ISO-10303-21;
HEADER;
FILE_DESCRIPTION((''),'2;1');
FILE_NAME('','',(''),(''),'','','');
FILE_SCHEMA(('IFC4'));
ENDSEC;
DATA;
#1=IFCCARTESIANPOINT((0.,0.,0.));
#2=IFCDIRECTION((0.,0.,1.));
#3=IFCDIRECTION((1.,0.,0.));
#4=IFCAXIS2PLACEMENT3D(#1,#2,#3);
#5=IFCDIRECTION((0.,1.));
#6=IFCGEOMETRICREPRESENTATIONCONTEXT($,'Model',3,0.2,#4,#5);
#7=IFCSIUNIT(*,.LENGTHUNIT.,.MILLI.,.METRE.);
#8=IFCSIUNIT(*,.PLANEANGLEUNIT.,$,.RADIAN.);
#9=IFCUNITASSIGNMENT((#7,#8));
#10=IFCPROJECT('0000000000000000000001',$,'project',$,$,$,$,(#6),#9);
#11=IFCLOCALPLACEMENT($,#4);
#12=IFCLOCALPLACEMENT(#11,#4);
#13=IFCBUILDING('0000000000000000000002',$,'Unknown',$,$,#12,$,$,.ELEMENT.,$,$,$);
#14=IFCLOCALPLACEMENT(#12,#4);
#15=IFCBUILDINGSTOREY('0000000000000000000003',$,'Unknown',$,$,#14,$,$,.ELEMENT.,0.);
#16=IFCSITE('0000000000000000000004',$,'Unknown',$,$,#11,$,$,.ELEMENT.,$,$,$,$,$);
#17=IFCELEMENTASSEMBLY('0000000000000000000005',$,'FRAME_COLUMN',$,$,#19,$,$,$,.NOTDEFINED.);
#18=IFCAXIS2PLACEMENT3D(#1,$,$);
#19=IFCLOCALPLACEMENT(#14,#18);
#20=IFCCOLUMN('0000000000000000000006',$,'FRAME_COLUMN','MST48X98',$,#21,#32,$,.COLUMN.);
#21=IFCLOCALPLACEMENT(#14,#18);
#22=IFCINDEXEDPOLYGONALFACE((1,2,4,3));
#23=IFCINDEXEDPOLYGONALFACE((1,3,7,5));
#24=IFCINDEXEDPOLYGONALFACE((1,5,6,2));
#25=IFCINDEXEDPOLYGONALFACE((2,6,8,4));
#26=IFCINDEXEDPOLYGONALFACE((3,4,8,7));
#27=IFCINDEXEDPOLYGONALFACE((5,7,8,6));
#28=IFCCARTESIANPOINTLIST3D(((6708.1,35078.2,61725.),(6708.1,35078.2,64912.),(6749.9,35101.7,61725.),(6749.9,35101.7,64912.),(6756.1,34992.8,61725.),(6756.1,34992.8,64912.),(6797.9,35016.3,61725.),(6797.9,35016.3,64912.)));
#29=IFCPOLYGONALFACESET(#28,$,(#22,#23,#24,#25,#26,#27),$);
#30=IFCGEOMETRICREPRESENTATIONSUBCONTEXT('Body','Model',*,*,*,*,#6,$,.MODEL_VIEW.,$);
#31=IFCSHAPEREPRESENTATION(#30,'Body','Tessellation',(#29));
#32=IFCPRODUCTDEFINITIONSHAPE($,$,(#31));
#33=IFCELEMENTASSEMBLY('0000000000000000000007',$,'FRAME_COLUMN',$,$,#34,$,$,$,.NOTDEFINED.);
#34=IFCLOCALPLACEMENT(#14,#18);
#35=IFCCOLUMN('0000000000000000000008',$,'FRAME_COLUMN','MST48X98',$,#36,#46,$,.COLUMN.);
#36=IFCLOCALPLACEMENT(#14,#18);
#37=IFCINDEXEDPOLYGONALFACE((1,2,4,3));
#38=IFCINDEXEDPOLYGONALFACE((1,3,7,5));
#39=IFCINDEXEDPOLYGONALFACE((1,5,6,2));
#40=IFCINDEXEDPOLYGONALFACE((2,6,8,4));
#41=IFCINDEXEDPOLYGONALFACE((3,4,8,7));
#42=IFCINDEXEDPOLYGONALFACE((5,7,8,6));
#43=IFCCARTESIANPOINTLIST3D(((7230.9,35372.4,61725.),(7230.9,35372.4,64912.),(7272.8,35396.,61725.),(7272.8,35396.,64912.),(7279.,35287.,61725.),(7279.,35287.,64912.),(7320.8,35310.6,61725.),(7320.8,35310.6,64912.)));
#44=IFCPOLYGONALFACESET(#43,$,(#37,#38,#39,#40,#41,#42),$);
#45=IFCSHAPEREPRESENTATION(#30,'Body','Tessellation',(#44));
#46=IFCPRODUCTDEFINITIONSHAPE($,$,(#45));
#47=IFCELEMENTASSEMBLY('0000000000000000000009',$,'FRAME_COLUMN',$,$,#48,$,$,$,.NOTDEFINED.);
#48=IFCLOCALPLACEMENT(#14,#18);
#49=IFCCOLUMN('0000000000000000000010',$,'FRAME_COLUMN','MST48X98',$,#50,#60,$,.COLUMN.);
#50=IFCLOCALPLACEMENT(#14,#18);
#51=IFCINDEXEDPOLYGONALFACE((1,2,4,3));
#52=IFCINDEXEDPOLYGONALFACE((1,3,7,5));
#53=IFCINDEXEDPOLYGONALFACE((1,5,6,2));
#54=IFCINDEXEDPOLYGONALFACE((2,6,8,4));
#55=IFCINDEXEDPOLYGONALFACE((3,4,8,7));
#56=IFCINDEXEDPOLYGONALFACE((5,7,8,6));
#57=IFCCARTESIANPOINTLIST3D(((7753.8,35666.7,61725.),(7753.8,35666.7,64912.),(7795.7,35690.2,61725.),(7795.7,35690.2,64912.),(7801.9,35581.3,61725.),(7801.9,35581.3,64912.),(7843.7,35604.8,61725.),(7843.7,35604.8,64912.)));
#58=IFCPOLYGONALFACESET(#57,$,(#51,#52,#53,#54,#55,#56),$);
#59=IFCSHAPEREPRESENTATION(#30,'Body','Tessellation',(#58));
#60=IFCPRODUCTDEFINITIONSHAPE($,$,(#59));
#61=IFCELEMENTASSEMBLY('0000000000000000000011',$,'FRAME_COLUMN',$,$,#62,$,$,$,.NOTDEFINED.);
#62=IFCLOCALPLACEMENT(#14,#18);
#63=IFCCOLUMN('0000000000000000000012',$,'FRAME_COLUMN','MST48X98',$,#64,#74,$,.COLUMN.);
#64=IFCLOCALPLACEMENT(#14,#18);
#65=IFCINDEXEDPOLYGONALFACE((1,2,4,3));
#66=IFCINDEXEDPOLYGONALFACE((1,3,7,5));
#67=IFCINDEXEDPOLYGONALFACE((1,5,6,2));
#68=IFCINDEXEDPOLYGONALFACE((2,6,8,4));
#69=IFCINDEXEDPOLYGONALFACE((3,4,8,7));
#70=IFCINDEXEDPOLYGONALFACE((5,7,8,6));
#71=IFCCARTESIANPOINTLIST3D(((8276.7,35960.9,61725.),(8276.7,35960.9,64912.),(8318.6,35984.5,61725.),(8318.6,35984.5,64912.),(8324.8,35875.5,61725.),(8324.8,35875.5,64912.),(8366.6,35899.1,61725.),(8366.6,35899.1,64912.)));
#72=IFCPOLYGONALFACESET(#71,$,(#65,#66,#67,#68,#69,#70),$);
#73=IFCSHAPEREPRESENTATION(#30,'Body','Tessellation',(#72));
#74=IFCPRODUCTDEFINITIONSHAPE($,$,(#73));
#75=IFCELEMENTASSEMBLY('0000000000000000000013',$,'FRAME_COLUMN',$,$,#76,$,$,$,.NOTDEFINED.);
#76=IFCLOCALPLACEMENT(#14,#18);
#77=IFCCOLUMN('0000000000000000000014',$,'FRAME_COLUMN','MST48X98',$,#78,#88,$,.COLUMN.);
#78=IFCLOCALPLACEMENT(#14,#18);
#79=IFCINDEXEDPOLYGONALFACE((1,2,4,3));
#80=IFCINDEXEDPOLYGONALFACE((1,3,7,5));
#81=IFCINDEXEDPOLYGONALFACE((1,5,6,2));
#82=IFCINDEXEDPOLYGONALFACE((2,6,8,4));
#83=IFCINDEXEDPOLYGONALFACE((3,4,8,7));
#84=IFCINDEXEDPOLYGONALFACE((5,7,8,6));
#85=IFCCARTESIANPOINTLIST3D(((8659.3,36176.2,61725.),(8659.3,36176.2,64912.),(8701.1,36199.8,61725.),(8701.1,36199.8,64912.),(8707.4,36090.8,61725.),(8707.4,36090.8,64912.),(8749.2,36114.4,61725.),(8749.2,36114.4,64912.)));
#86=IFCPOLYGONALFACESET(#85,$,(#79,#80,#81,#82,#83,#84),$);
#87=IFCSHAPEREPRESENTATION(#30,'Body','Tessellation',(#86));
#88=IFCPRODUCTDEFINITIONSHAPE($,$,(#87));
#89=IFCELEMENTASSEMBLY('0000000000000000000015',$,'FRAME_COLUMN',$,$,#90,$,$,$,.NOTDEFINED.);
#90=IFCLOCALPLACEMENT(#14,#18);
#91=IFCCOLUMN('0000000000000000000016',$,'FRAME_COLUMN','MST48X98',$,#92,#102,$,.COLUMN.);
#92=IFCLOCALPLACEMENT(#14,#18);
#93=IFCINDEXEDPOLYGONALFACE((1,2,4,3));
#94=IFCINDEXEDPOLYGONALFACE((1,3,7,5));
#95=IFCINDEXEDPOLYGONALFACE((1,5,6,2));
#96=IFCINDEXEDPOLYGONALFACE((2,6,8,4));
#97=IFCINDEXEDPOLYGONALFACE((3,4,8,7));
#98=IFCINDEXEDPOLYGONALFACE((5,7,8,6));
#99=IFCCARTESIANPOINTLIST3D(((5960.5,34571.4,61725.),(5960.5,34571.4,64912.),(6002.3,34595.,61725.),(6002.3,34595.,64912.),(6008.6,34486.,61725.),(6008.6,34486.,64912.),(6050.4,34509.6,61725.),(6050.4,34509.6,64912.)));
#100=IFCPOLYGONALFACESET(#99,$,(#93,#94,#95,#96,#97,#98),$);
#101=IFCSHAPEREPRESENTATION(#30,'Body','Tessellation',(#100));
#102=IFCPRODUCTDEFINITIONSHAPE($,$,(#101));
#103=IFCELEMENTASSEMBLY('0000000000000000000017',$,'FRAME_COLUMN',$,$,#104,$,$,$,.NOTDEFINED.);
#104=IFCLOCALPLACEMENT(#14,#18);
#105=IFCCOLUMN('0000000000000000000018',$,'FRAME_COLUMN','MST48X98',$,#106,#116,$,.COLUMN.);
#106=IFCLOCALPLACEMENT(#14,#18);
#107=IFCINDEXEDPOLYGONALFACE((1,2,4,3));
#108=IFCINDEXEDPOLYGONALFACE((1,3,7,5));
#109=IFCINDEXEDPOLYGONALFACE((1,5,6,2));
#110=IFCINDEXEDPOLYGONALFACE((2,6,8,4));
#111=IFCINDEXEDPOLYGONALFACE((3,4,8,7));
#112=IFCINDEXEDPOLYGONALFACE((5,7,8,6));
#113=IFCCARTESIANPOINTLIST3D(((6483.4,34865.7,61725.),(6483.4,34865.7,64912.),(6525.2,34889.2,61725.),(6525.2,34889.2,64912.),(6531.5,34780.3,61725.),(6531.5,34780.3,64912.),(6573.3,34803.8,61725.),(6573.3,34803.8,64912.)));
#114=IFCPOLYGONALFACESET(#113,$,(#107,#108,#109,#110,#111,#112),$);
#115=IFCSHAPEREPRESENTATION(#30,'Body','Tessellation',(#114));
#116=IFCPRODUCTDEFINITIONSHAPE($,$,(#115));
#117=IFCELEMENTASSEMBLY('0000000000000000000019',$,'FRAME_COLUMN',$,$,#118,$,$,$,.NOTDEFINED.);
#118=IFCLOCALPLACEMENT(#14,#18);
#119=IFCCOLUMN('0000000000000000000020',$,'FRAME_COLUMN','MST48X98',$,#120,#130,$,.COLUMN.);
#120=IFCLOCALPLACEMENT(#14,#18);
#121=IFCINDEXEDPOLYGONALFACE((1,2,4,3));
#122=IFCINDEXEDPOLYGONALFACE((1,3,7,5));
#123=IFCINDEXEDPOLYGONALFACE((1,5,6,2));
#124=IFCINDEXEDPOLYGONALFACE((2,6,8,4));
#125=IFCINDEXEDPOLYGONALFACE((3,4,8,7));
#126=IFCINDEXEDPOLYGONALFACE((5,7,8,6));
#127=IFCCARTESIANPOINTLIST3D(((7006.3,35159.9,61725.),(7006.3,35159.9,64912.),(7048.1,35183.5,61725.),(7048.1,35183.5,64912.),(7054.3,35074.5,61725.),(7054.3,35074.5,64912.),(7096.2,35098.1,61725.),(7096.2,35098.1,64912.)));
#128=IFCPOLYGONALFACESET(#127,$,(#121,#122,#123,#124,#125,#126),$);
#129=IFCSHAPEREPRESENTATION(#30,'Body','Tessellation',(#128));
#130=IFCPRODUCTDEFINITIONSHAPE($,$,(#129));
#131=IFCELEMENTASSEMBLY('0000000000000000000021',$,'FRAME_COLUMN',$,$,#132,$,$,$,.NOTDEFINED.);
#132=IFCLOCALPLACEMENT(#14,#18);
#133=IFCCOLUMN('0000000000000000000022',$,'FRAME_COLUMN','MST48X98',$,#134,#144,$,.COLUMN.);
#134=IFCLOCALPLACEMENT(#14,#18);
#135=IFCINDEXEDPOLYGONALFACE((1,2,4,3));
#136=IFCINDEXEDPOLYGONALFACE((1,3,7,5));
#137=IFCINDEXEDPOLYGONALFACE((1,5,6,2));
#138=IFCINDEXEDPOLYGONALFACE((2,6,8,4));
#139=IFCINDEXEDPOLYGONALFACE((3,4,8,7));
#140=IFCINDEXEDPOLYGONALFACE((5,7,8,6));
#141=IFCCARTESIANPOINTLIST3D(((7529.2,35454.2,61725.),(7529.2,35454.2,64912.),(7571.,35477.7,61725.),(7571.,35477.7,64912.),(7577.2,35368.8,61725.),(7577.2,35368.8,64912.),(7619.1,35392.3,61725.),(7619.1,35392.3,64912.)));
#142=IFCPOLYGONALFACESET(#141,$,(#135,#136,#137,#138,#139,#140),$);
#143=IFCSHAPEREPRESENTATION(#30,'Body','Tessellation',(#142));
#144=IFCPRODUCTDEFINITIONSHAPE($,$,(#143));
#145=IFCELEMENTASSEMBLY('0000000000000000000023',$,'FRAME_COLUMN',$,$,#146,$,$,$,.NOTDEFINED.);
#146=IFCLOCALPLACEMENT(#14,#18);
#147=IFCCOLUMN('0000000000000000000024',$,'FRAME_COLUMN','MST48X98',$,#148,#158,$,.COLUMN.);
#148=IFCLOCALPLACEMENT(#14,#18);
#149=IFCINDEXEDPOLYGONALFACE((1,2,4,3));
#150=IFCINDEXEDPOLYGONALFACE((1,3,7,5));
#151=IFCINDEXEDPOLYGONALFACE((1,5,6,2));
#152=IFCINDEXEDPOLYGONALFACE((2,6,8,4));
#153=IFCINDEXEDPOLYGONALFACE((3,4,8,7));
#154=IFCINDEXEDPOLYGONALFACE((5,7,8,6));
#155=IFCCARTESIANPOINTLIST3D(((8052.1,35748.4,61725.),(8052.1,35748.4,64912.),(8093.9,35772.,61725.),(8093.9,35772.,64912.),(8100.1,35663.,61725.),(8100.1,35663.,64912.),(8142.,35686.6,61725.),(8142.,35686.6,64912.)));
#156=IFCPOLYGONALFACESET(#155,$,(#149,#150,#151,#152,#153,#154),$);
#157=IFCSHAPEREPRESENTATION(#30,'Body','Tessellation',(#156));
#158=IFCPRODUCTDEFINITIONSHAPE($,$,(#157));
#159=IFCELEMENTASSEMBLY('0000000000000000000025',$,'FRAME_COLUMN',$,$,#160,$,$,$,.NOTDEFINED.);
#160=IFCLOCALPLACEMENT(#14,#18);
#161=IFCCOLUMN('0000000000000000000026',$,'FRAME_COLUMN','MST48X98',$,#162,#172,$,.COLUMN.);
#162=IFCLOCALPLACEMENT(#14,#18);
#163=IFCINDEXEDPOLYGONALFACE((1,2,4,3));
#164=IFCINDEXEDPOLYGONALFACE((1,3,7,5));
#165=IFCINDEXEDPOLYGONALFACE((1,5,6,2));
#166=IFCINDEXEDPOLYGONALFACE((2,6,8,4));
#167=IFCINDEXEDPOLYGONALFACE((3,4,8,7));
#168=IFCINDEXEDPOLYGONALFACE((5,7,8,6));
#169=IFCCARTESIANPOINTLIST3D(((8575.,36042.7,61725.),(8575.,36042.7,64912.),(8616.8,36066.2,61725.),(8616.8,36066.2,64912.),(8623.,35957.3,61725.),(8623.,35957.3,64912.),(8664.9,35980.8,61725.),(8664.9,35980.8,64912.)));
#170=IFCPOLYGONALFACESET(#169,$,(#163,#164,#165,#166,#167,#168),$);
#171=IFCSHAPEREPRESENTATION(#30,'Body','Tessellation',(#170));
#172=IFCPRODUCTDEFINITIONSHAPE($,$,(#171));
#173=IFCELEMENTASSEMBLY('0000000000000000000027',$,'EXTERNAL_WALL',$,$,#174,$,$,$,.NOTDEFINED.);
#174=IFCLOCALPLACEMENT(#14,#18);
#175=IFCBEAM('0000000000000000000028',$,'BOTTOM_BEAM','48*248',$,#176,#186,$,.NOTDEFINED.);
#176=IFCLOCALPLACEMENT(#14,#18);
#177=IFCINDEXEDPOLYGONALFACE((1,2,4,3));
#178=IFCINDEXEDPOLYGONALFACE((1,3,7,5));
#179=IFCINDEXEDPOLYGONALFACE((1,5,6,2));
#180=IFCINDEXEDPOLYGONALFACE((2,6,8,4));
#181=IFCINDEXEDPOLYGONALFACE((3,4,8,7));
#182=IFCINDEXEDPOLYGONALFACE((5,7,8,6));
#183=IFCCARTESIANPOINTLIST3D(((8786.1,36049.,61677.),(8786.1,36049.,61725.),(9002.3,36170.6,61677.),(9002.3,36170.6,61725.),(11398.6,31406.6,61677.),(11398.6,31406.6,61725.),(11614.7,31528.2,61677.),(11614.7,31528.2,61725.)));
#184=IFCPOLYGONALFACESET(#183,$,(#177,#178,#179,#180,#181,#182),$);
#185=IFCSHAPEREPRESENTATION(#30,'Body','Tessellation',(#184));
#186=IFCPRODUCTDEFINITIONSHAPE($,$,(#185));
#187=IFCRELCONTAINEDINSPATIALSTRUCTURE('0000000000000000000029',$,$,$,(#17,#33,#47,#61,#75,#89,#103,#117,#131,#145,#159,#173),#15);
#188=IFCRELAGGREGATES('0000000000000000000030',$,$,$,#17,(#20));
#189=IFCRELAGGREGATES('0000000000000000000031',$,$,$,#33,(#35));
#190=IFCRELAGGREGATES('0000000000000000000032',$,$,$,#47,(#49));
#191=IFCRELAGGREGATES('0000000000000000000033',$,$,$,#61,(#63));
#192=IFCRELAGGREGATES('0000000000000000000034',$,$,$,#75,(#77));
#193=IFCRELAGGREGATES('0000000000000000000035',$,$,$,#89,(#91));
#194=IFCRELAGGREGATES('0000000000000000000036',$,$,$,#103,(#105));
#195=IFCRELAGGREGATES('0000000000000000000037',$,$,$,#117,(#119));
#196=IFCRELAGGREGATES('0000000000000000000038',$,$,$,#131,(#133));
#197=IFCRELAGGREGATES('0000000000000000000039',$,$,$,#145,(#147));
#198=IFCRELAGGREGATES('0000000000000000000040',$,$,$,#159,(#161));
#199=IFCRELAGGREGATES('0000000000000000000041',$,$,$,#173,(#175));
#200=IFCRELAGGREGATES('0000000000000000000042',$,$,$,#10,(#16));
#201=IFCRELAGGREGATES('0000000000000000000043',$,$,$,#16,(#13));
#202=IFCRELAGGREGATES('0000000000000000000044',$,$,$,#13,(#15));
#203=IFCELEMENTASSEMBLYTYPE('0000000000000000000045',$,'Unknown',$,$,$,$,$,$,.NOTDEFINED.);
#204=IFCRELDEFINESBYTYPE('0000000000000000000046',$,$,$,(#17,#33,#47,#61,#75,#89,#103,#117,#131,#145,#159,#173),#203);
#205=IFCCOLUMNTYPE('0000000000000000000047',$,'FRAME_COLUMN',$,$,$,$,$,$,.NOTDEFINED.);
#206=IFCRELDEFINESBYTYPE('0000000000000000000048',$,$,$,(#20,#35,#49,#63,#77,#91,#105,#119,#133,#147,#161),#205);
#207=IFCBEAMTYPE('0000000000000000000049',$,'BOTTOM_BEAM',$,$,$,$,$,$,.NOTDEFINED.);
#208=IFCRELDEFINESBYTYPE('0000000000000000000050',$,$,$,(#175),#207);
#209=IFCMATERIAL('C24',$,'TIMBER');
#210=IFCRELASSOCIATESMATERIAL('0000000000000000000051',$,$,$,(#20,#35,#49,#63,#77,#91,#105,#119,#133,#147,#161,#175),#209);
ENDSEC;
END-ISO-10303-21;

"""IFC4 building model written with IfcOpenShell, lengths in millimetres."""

from ifc_helpers import new_model, si_unit, direction, frame, origin_with_axes, origin_2d_with_axis, place, context, subcontext, project, spatial, polyline, rectangle, outline, extrude, material, material_profile, profile_set, profile_usage, type_object, element, aggregate, save


model = new_model("IFC4")

# Units and contexts
model_context = context("Model", 3, precision=0.2, world=origin_with_axes(), true_north=direction((0.0, 1.0)))
body_context = subcontext(model_context, "Body", "Model", "MODEL_VIEW")
ifc_project = project(units=[si_unit("LENGTHUNIT", "METRE", prefix="MILLI"), si_unit("PLANEANGLEUNIT", "RADIAN")], contexts=[model_context])

# Site, building, storey
site_placement = place(None, origin_with_axes())
site = spatial("IfcSite", under=ifc_project, at=site_placement, Name="Unknown", CompositionType="ELEMENT")
building_placement = place(site_placement, origin_with_axes())
building = spatial("IfcBuilding", under=site, at=building_placement, Name="Unknown", CompositionType="ELEMENT")
storey_placement = place(building_placement, origin_with_axes())
storey = spatial("IfcBuildingStorey", under=building, at=storey_placement, Name="Unknown", CompositionType="ELEMENT", Elevation=0.0)

# Element assemblies, columns
element_assembly_type = type_object("IfcElementAssemblyType", Name="Unknown", PredefinedType="NOTDEFINED")
ifc_material = material(Name="C24", Category="TIMBER")
ifc_material_profile_1 = material_profile(ifc_material, outline(polyline([(-24.0, 49.0), (-24.0, -49.0), (24.0, -49.0), (24.0, 49.0), (-24.0, 49.0)])), Name="MST48X98")
ifc_profile_set_1 = profile_set([ifc_material_profile_1])
ifc_profile_usage_1 = profile_usage(ifc_profile_set_1, cardinal=7)
column_type = type_object("IfcColumnType", Name="FRAME_COLUMN")
ifc_profile_usage_2 = profile_usage(ifc_profile_set_1, cardinal=9)
assembly_1_placement = place(storey_placement, frame((6753.0, 35047.2, 61725.0), z_axis=(-0.871487, -0.490418, 0.0), x_axis=(0.0, 0.0, 1.0)))
assembly_1 = element("IfcElementAssembly", 1, at=assembly_1_placement, inside=storey, type_object=element_assembly_type, Name="FRAME_COLUMN", PredefinedType="NOTDEFINED")
column_1_placement = place(assembly_1_placement, origin_with_axes())
column_1 = element("IfcColumn", 2, at=column_1_placement, type_object=column_type, material=ifc_profile_usage_1, Name="FRAME_COLUMN", Description="MST48X98", PredefinedType="COLUMN", context=body_context, shape_type="SolidModel", body=[
    extrude(outline(polyline([(-24.0, 49.0), (-24.0, -49.0), (24.0, -49.0), (24.0, 49.0), (-24.0, 49.0)])), frame((0.0, 0.0, 0.0), z_axis=(-1.0, 0.0, 0.0), x_axis=(0.0, 0.0, 1.0)), (0.0, 0.0, -1.0), 3187.0),
])
aggregate(assembly_1, [column_1])
assembly_2_placement = place(storey_placement, frame((7275.9, 35341.5, 61725.0), z_axis=(-0.871487, -0.490418, 0.0), x_axis=(0.0, 0.0, 1.0)))
assembly_2 = element("IfcElementAssembly", 3, at=assembly_2_placement, inside=storey, type_object=element_assembly_type, Name="FRAME_COLUMN", PredefinedType="NOTDEFINED")
column_2_placement = place(assembly_2_placement, origin_with_axes())
column_2 = element("IfcColumn", 4, at=column_2_placement, type_object=column_type, material=ifc_profile_usage_1, Name="FRAME_COLUMN", Description="MST48X98", PredefinedType="COLUMN", context=body_context, shape_type="SolidModel", body=[
    extrude(outline(polyline([(-24.0, 49.0), (-24.0, -49.0), (24.0, -49.0), (24.0, 49.0), (-24.0, 49.0)])), frame((0.0, 0.0, 0.0), z_axis=(-1.0, 0.0, 0.0), x_axis=(0.0, 0.0, 1.0)), (0.0, 0.0, -1.0), 3187.0),
])
aggregate(assembly_2, [column_2])
assembly_3_placement = place(storey_placement, frame((7798.8, 35635.7, 61725.0), z_axis=(-0.871487, -0.490418, 0.0), x_axis=(0.0, 0.0, 1.0)))
assembly_3 = element("IfcElementAssembly", 5, at=assembly_3_placement, inside=storey, type_object=element_assembly_type, Name="FRAME_COLUMN", PredefinedType="NOTDEFINED")
column_3_placement = place(assembly_3_placement, origin_with_axes())
column_3 = element("IfcColumn", 6, at=column_3_placement, type_object=column_type, material=ifc_profile_usage_1, Name="FRAME_COLUMN", Description="MST48X98", PredefinedType="COLUMN", context=body_context, shape_type="SolidModel", body=[
    extrude(outline(polyline([(-24.0, 49.0), (-24.0, -49.0), (24.0, -49.0), (24.0, 49.0), (-24.0, 49.0)])), frame((0.0, 0.0, 0.0), z_axis=(-1.0, 0.0, 0.0), x_axis=(0.0, 0.0, 1.0)), (0.0, 0.0, -1.0), 3187.0),
])
aggregate(assembly_3, [column_3])
assembly_4_placement = place(storey_placement, frame((8321.7, 35930.0, 61725.0), z_axis=(-0.871487, -0.490418, 0.0), x_axis=(0.0, 0.0, 1.0)))
assembly_4 = element("IfcElementAssembly", 7, at=assembly_4_placement, inside=storey, type_object=element_assembly_type, Name="FRAME_COLUMN", PredefinedType="NOTDEFINED")
column_4_placement = place(assembly_4_placement, origin_with_axes())
column_4 = element("IfcColumn", 8, at=column_4_placement, type_object=column_type, material=ifc_profile_usage_1, Name="FRAME_COLUMN", Description="MST48X98", PredefinedType="COLUMN", context=body_context, shape_type="SolidModel", body=[
    extrude(outline(polyline([(-24.0, 49.0), (-24.0, -49.0), (24.0, -49.0), (24.0, 49.0), (-24.0, 49.0)])), frame((0.0, 0.0, 0.0), z_axis=(-1.0, 0.0, 0.0), x_axis=(0.0, 0.0, 1.0)), (0.0, 0.0, -1.0), 3187.0),
])
aggregate(assembly_4, [column_4])
assembly_5_placement = place(storey_placement, frame((8704.3, 36145.3, 61725.0), z_axis=(-0.871487, -0.490418, 0.0), x_axis=(0.0, 0.0, 1.0)))
assembly_5 = element("IfcElementAssembly", 9, at=assembly_5_placement, inside=storey, type_object=element_assembly_type, Name="FRAME_COLUMN", PredefinedType="NOTDEFINED")
column_5_placement = place(assembly_5_placement, origin_with_axes())
column_5 = element("IfcColumn", 10, at=column_5_placement, type_object=column_type, material=ifc_profile_usage_1, Name="FRAME_COLUMN", Description="MST48X98", PredefinedType="COLUMN", context=body_context, shape_type="SolidModel", body=[
    extrude(outline(polyline([(-24.0, 49.0), (-24.0, -49.0), (24.0, -49.0), (24.0, 49.0), (-24.0, 49.0)])), frame((0.0, 0.0, 0.0), z_axis=(-1.0, 0.0, 0.0), x_axis=(0.0, 0.0, 1.0)), (0.0, 0.0, -1.0), 3187.0),
])
aggregate(assembly_5, [column_5])
assembly_6_placement = place(storey_placement, frame((6005.4, 34540.5, 61725.0), z_axis=(-0.871487, -0.490418, 0.0), x_axis=(0.0, 0.0, 1.0)))
assembly_6 = element("IfcElementAssembly", 11, at=assembly_6_placement, inside=storey, type_object=element_assembly_type, Name="FRAME_COLUMN", PredefinedType="NOTDEFINED")
column_6_placement = place(assembly_6_placement, origin_with_axes())
column_6 = element("IfcColumn", 12, at=column_6_placement, type_object=column_type, material=ifc_profile_usage_2, Name="FRAME_COLUMN", Description="MST48X98", PredefinedType="COLUMN", context=body_context, shape_type="SolidModel", body=[
    extrude(outline(polyline([(-24.0, 49.0), (-24.0, -49.0), (24.0, -49.0), (24.0, 49.0), (-24.0, 49.0)])), frame((0.0, 0.0, 0.0), z_axis=(-1.0, 0.0, 0.0), x_axis=(0.0, 0.0, 1.0)), (0.0, 0.0, -1.0), 3187.0),
])
aggregate(assembly_6, [column_6])
assembly_7_placement = place(storey_placement, frame((6528.3, 34834.8, 61725.0), z_axis=(-0.871487, -0.490418, 0.0), x_axis=(0.0, 0.0, 1.0)))
assembly_7 = element("IfcElementAssembly", 13, at=assembly_7_placement, inside=storey, type_object=element_assembly_type, Name="FRAME_COLUMN", PredefinedType="NOTDEFINED")
column_7_placement = place(assembly_7_placement, origin_with_axes())
column_7 = element("IfcColumn", 14, at=column_7_placement, type_object=column_type, material=ifc_profile_usage_2, Name="FRAME_COLUMN", Description="MST48X98", PredefinedType="COLUMN", context=body_context, shape_type="SolidModel", body=[
    extrude(outline(polyline([(-24.0, 49.0), (-24.0, -49.0), (24.0, -49.0), (24.0, 49.0), (-24.0, 49.0)])), frame((0.0, 0.0, 0.0), z_axis=(-1.0, 0.0, 0.0), x_axis=(0.0, 0.0, 1.0)), (0.0, 0.0, -1.0), 3187.0),
])
aggregate(assembly_7, [column_7])
assembly_8_placement = place(storey_placement, frame((7051.2, 35129.0, 61725.0), z_axis=(-0.871487, -0.490418, 0.0), x_axis=(0.0, 0.0, 1.0)))
assembly_8 = element("IfcElementAssembly", 15, at=assembly_8_placement, inside=storey, type_object=element_assembly_type, Name="FRAME_COLUMN", PredefinedType="NOTDEFINED")
column_8_placement = place(assembly_8_placement, origin_with_axes())
column_8 = element("IfcColumn", 16, at=column_8_placement, type_object=column_type, material=ifc_profile_usage_2, Name="FRAME_COLUMN", Description="MST48X98", PredefinedType="COLUMN", context=body_context, shape_type="SolidModel", body=[
    extrude(outline(polyline([(-24.0, 49.0), (-24.0, -49.0), (24.0, -49.0), (24.0, 49.0), (-24.0, 49.0)])), frame((0.0, 0.0, 0.0), z_axis=(-1.0, 0.0, 0.0), x_axis=(0.0, 0.0, 1.0)), (0.0, 0.0, -1.0), 3187.0),
])
aggregate(assembly_8, [column_8])
assembly_9_placement = place(storey_placement, frame((7574.1, 35423.3, 61725.0), z_axis=(-0.871487, -0.490418, 0.0), x_axis=(0.0, 0.0, 1.0)))
assembly_9 = element("IfcElementAssembly", 17, at=assembly_9_placement, inside=storey, type_object=element_assembly_type, Name="FRAME_COLUMN", PredefinedType="NOTDEFINED")
column_9_placement = place(assembly_9_placement, origin_with_axes())
column_9 = element("IfcColumn", 18, at=column_9_placement, type_object=column_type, material=ifc_profile_usage_2, Name="FRAME_COLUMN", Description="MST48X98", PredefinedType="COLUMN", context=body_context, shape_type="SolidModel", body=[
    extrude(outline(polyline([(-24.0, 49.0), (-24.0, -49.0), (24.0, -49.0), (24.0, 49.0), (-24.0, 49.0)])), frame((0.0, 0.0, 0.0), z_axis=(-1.0, 0.0, 0.0), x_axis=(0.0, 0.0, 1.0)), (0.0, 0.0, -1.0), 3187.0),
])
aggregate(assembly_9, [column_9])
assembly_10_placement = place(storey_placement, frame((8097.0, 35717.5, 61725.0), z_axis=(-0.871487, -0.490418, 0.0), x_axis=(0.0, 0.0, 1.0)))
assembly_10 = element("IfcElementAssembly", 19, at=assembly_10_placement, inside=storey, type_object=element_assembly_type, Name="FRAME_COLUMN", PredefinedType="NOTDEFINED")
column_10_placement = place(assembly_10_placement, origin_with_axes())
column_10 = element("IfcColumn", 20, at=column_10_placement, type_object=column_type, material=ifc_profile_usage_2, Name="FRAME_COLUMN", Description="MST48X98", PredefinedType="COLUMN", context=body_context, shape_type="SolidModel", body=[
    extrude(outline(polyline([(-24.0, 49.0), (-24.0, -49.0), (24.0, -49.0), (24.0, 49.0), (-24.0, 49.0)])), frame((0.0, 0.0, 0.0), z_axis=(-1.0, 0.0, 0.0), x_axis=(0.0, 0.0, 1.0)), (0.0, 0.0, -1.0), 3187.0),
])
aggregate(assembly_10, [column_10])
assembly_11_placement = place(storey_placement, frame((8619.9, 36011.8, 61725.0), z_axis=(-0.871487, -0.490418, 0.0), x_axis=(0.0, 0.0, 1.0)))
assembly_11 = element("IfcElementAssembly", 21, at=assembly_11_placement, inside=storey, type_object=element_assembly_type, Name="FRAME_COLUMN", PredefinedType="NOTDEFINED")
column_11_placement = place(assembly_11_placement, origin_with_axes())
column_11 = element("IfcColumn", 22, at=column_11_placement, type_object=column_type, material=ifc_profile_usage_2, Name="FRAME_COLUMN", Description="MST48X98", PredefinedType="COLUMN", context=body_context, shape_type="SolidModel", body=[
    extrude(outline(polyline([(-24.0, 49.0), (-24.0, -49.0), (24.0, -49.0), (24.0, 49.0), (-24.0, 49.0)])), frame((0.0, 0.0, 0.0), z_axis=(-1.0, 0.0, 0.0), x_axis=(0.0, 0.0, 1.0)), (0.0, 0.0, -1.0), 3187.0),
])
aggregate(assembly_11, [column_11])

# Element assembly, beam
assembly_12_placement = place(storey_placement, frame((8894.2, 36109.8, 64936.0), z_axis=(-0.871487, -0.490418, 0.0), x_axis=(0.490421, -0.871485, 0.0)))
assembly_12 = element("IfcElementAssembly", 23, at=assembly_12_placement, inside=storey, type_object=element_assembly_type, Name="EXTERNAL_WALL", PredefinedType="NOTDEFINED")
ifc_material_profile_2 = material_profile(ifc_material, rectangle(XDim=248.0, YDim=48.0, at=origin_2d_with_axis()), Name="48*248")
ifc_profile_set_2 = profile_set([ifc_material_profile_2])
ifc_profile_usage_3 = profile_usage(ifc_profile_set_2, cardinal=3)
beam_type_1 = type_object("IfcBeamType", Name="BOTTOM_BEAM")
beam_1_placement = place(assembly_12_placement, frame((0.0, -3235.0, 0.0), z_axis=(0.0, 0.0, 1.0), x_axis=(1.0, 0.0, 0.0)))
beam_1 = element("IfcBeam", 24, at=beam_1_placement, type_object=beam_type_1, material=ifc_profile_usage_3, Name="BOTTOM_BEAM", Description="48*248", PredefinedType="NOTDEFINED", context=body_context, shape_type="SolidModel", body=[
    extrude(rectangle(XDim=248.0, YDim=48.0, at=origin_2d_with_axis()), frame((0.0, 0.0, 0.0), z_axis=(-1.0, 0.0, 0.0), x_axis=(0.0, 0.0, 1.0)), (0.0, 0.0, -1.0), 5327.0),
])

aggregate(assembly_12, [beam_1])

save(model, "model.ifc")
